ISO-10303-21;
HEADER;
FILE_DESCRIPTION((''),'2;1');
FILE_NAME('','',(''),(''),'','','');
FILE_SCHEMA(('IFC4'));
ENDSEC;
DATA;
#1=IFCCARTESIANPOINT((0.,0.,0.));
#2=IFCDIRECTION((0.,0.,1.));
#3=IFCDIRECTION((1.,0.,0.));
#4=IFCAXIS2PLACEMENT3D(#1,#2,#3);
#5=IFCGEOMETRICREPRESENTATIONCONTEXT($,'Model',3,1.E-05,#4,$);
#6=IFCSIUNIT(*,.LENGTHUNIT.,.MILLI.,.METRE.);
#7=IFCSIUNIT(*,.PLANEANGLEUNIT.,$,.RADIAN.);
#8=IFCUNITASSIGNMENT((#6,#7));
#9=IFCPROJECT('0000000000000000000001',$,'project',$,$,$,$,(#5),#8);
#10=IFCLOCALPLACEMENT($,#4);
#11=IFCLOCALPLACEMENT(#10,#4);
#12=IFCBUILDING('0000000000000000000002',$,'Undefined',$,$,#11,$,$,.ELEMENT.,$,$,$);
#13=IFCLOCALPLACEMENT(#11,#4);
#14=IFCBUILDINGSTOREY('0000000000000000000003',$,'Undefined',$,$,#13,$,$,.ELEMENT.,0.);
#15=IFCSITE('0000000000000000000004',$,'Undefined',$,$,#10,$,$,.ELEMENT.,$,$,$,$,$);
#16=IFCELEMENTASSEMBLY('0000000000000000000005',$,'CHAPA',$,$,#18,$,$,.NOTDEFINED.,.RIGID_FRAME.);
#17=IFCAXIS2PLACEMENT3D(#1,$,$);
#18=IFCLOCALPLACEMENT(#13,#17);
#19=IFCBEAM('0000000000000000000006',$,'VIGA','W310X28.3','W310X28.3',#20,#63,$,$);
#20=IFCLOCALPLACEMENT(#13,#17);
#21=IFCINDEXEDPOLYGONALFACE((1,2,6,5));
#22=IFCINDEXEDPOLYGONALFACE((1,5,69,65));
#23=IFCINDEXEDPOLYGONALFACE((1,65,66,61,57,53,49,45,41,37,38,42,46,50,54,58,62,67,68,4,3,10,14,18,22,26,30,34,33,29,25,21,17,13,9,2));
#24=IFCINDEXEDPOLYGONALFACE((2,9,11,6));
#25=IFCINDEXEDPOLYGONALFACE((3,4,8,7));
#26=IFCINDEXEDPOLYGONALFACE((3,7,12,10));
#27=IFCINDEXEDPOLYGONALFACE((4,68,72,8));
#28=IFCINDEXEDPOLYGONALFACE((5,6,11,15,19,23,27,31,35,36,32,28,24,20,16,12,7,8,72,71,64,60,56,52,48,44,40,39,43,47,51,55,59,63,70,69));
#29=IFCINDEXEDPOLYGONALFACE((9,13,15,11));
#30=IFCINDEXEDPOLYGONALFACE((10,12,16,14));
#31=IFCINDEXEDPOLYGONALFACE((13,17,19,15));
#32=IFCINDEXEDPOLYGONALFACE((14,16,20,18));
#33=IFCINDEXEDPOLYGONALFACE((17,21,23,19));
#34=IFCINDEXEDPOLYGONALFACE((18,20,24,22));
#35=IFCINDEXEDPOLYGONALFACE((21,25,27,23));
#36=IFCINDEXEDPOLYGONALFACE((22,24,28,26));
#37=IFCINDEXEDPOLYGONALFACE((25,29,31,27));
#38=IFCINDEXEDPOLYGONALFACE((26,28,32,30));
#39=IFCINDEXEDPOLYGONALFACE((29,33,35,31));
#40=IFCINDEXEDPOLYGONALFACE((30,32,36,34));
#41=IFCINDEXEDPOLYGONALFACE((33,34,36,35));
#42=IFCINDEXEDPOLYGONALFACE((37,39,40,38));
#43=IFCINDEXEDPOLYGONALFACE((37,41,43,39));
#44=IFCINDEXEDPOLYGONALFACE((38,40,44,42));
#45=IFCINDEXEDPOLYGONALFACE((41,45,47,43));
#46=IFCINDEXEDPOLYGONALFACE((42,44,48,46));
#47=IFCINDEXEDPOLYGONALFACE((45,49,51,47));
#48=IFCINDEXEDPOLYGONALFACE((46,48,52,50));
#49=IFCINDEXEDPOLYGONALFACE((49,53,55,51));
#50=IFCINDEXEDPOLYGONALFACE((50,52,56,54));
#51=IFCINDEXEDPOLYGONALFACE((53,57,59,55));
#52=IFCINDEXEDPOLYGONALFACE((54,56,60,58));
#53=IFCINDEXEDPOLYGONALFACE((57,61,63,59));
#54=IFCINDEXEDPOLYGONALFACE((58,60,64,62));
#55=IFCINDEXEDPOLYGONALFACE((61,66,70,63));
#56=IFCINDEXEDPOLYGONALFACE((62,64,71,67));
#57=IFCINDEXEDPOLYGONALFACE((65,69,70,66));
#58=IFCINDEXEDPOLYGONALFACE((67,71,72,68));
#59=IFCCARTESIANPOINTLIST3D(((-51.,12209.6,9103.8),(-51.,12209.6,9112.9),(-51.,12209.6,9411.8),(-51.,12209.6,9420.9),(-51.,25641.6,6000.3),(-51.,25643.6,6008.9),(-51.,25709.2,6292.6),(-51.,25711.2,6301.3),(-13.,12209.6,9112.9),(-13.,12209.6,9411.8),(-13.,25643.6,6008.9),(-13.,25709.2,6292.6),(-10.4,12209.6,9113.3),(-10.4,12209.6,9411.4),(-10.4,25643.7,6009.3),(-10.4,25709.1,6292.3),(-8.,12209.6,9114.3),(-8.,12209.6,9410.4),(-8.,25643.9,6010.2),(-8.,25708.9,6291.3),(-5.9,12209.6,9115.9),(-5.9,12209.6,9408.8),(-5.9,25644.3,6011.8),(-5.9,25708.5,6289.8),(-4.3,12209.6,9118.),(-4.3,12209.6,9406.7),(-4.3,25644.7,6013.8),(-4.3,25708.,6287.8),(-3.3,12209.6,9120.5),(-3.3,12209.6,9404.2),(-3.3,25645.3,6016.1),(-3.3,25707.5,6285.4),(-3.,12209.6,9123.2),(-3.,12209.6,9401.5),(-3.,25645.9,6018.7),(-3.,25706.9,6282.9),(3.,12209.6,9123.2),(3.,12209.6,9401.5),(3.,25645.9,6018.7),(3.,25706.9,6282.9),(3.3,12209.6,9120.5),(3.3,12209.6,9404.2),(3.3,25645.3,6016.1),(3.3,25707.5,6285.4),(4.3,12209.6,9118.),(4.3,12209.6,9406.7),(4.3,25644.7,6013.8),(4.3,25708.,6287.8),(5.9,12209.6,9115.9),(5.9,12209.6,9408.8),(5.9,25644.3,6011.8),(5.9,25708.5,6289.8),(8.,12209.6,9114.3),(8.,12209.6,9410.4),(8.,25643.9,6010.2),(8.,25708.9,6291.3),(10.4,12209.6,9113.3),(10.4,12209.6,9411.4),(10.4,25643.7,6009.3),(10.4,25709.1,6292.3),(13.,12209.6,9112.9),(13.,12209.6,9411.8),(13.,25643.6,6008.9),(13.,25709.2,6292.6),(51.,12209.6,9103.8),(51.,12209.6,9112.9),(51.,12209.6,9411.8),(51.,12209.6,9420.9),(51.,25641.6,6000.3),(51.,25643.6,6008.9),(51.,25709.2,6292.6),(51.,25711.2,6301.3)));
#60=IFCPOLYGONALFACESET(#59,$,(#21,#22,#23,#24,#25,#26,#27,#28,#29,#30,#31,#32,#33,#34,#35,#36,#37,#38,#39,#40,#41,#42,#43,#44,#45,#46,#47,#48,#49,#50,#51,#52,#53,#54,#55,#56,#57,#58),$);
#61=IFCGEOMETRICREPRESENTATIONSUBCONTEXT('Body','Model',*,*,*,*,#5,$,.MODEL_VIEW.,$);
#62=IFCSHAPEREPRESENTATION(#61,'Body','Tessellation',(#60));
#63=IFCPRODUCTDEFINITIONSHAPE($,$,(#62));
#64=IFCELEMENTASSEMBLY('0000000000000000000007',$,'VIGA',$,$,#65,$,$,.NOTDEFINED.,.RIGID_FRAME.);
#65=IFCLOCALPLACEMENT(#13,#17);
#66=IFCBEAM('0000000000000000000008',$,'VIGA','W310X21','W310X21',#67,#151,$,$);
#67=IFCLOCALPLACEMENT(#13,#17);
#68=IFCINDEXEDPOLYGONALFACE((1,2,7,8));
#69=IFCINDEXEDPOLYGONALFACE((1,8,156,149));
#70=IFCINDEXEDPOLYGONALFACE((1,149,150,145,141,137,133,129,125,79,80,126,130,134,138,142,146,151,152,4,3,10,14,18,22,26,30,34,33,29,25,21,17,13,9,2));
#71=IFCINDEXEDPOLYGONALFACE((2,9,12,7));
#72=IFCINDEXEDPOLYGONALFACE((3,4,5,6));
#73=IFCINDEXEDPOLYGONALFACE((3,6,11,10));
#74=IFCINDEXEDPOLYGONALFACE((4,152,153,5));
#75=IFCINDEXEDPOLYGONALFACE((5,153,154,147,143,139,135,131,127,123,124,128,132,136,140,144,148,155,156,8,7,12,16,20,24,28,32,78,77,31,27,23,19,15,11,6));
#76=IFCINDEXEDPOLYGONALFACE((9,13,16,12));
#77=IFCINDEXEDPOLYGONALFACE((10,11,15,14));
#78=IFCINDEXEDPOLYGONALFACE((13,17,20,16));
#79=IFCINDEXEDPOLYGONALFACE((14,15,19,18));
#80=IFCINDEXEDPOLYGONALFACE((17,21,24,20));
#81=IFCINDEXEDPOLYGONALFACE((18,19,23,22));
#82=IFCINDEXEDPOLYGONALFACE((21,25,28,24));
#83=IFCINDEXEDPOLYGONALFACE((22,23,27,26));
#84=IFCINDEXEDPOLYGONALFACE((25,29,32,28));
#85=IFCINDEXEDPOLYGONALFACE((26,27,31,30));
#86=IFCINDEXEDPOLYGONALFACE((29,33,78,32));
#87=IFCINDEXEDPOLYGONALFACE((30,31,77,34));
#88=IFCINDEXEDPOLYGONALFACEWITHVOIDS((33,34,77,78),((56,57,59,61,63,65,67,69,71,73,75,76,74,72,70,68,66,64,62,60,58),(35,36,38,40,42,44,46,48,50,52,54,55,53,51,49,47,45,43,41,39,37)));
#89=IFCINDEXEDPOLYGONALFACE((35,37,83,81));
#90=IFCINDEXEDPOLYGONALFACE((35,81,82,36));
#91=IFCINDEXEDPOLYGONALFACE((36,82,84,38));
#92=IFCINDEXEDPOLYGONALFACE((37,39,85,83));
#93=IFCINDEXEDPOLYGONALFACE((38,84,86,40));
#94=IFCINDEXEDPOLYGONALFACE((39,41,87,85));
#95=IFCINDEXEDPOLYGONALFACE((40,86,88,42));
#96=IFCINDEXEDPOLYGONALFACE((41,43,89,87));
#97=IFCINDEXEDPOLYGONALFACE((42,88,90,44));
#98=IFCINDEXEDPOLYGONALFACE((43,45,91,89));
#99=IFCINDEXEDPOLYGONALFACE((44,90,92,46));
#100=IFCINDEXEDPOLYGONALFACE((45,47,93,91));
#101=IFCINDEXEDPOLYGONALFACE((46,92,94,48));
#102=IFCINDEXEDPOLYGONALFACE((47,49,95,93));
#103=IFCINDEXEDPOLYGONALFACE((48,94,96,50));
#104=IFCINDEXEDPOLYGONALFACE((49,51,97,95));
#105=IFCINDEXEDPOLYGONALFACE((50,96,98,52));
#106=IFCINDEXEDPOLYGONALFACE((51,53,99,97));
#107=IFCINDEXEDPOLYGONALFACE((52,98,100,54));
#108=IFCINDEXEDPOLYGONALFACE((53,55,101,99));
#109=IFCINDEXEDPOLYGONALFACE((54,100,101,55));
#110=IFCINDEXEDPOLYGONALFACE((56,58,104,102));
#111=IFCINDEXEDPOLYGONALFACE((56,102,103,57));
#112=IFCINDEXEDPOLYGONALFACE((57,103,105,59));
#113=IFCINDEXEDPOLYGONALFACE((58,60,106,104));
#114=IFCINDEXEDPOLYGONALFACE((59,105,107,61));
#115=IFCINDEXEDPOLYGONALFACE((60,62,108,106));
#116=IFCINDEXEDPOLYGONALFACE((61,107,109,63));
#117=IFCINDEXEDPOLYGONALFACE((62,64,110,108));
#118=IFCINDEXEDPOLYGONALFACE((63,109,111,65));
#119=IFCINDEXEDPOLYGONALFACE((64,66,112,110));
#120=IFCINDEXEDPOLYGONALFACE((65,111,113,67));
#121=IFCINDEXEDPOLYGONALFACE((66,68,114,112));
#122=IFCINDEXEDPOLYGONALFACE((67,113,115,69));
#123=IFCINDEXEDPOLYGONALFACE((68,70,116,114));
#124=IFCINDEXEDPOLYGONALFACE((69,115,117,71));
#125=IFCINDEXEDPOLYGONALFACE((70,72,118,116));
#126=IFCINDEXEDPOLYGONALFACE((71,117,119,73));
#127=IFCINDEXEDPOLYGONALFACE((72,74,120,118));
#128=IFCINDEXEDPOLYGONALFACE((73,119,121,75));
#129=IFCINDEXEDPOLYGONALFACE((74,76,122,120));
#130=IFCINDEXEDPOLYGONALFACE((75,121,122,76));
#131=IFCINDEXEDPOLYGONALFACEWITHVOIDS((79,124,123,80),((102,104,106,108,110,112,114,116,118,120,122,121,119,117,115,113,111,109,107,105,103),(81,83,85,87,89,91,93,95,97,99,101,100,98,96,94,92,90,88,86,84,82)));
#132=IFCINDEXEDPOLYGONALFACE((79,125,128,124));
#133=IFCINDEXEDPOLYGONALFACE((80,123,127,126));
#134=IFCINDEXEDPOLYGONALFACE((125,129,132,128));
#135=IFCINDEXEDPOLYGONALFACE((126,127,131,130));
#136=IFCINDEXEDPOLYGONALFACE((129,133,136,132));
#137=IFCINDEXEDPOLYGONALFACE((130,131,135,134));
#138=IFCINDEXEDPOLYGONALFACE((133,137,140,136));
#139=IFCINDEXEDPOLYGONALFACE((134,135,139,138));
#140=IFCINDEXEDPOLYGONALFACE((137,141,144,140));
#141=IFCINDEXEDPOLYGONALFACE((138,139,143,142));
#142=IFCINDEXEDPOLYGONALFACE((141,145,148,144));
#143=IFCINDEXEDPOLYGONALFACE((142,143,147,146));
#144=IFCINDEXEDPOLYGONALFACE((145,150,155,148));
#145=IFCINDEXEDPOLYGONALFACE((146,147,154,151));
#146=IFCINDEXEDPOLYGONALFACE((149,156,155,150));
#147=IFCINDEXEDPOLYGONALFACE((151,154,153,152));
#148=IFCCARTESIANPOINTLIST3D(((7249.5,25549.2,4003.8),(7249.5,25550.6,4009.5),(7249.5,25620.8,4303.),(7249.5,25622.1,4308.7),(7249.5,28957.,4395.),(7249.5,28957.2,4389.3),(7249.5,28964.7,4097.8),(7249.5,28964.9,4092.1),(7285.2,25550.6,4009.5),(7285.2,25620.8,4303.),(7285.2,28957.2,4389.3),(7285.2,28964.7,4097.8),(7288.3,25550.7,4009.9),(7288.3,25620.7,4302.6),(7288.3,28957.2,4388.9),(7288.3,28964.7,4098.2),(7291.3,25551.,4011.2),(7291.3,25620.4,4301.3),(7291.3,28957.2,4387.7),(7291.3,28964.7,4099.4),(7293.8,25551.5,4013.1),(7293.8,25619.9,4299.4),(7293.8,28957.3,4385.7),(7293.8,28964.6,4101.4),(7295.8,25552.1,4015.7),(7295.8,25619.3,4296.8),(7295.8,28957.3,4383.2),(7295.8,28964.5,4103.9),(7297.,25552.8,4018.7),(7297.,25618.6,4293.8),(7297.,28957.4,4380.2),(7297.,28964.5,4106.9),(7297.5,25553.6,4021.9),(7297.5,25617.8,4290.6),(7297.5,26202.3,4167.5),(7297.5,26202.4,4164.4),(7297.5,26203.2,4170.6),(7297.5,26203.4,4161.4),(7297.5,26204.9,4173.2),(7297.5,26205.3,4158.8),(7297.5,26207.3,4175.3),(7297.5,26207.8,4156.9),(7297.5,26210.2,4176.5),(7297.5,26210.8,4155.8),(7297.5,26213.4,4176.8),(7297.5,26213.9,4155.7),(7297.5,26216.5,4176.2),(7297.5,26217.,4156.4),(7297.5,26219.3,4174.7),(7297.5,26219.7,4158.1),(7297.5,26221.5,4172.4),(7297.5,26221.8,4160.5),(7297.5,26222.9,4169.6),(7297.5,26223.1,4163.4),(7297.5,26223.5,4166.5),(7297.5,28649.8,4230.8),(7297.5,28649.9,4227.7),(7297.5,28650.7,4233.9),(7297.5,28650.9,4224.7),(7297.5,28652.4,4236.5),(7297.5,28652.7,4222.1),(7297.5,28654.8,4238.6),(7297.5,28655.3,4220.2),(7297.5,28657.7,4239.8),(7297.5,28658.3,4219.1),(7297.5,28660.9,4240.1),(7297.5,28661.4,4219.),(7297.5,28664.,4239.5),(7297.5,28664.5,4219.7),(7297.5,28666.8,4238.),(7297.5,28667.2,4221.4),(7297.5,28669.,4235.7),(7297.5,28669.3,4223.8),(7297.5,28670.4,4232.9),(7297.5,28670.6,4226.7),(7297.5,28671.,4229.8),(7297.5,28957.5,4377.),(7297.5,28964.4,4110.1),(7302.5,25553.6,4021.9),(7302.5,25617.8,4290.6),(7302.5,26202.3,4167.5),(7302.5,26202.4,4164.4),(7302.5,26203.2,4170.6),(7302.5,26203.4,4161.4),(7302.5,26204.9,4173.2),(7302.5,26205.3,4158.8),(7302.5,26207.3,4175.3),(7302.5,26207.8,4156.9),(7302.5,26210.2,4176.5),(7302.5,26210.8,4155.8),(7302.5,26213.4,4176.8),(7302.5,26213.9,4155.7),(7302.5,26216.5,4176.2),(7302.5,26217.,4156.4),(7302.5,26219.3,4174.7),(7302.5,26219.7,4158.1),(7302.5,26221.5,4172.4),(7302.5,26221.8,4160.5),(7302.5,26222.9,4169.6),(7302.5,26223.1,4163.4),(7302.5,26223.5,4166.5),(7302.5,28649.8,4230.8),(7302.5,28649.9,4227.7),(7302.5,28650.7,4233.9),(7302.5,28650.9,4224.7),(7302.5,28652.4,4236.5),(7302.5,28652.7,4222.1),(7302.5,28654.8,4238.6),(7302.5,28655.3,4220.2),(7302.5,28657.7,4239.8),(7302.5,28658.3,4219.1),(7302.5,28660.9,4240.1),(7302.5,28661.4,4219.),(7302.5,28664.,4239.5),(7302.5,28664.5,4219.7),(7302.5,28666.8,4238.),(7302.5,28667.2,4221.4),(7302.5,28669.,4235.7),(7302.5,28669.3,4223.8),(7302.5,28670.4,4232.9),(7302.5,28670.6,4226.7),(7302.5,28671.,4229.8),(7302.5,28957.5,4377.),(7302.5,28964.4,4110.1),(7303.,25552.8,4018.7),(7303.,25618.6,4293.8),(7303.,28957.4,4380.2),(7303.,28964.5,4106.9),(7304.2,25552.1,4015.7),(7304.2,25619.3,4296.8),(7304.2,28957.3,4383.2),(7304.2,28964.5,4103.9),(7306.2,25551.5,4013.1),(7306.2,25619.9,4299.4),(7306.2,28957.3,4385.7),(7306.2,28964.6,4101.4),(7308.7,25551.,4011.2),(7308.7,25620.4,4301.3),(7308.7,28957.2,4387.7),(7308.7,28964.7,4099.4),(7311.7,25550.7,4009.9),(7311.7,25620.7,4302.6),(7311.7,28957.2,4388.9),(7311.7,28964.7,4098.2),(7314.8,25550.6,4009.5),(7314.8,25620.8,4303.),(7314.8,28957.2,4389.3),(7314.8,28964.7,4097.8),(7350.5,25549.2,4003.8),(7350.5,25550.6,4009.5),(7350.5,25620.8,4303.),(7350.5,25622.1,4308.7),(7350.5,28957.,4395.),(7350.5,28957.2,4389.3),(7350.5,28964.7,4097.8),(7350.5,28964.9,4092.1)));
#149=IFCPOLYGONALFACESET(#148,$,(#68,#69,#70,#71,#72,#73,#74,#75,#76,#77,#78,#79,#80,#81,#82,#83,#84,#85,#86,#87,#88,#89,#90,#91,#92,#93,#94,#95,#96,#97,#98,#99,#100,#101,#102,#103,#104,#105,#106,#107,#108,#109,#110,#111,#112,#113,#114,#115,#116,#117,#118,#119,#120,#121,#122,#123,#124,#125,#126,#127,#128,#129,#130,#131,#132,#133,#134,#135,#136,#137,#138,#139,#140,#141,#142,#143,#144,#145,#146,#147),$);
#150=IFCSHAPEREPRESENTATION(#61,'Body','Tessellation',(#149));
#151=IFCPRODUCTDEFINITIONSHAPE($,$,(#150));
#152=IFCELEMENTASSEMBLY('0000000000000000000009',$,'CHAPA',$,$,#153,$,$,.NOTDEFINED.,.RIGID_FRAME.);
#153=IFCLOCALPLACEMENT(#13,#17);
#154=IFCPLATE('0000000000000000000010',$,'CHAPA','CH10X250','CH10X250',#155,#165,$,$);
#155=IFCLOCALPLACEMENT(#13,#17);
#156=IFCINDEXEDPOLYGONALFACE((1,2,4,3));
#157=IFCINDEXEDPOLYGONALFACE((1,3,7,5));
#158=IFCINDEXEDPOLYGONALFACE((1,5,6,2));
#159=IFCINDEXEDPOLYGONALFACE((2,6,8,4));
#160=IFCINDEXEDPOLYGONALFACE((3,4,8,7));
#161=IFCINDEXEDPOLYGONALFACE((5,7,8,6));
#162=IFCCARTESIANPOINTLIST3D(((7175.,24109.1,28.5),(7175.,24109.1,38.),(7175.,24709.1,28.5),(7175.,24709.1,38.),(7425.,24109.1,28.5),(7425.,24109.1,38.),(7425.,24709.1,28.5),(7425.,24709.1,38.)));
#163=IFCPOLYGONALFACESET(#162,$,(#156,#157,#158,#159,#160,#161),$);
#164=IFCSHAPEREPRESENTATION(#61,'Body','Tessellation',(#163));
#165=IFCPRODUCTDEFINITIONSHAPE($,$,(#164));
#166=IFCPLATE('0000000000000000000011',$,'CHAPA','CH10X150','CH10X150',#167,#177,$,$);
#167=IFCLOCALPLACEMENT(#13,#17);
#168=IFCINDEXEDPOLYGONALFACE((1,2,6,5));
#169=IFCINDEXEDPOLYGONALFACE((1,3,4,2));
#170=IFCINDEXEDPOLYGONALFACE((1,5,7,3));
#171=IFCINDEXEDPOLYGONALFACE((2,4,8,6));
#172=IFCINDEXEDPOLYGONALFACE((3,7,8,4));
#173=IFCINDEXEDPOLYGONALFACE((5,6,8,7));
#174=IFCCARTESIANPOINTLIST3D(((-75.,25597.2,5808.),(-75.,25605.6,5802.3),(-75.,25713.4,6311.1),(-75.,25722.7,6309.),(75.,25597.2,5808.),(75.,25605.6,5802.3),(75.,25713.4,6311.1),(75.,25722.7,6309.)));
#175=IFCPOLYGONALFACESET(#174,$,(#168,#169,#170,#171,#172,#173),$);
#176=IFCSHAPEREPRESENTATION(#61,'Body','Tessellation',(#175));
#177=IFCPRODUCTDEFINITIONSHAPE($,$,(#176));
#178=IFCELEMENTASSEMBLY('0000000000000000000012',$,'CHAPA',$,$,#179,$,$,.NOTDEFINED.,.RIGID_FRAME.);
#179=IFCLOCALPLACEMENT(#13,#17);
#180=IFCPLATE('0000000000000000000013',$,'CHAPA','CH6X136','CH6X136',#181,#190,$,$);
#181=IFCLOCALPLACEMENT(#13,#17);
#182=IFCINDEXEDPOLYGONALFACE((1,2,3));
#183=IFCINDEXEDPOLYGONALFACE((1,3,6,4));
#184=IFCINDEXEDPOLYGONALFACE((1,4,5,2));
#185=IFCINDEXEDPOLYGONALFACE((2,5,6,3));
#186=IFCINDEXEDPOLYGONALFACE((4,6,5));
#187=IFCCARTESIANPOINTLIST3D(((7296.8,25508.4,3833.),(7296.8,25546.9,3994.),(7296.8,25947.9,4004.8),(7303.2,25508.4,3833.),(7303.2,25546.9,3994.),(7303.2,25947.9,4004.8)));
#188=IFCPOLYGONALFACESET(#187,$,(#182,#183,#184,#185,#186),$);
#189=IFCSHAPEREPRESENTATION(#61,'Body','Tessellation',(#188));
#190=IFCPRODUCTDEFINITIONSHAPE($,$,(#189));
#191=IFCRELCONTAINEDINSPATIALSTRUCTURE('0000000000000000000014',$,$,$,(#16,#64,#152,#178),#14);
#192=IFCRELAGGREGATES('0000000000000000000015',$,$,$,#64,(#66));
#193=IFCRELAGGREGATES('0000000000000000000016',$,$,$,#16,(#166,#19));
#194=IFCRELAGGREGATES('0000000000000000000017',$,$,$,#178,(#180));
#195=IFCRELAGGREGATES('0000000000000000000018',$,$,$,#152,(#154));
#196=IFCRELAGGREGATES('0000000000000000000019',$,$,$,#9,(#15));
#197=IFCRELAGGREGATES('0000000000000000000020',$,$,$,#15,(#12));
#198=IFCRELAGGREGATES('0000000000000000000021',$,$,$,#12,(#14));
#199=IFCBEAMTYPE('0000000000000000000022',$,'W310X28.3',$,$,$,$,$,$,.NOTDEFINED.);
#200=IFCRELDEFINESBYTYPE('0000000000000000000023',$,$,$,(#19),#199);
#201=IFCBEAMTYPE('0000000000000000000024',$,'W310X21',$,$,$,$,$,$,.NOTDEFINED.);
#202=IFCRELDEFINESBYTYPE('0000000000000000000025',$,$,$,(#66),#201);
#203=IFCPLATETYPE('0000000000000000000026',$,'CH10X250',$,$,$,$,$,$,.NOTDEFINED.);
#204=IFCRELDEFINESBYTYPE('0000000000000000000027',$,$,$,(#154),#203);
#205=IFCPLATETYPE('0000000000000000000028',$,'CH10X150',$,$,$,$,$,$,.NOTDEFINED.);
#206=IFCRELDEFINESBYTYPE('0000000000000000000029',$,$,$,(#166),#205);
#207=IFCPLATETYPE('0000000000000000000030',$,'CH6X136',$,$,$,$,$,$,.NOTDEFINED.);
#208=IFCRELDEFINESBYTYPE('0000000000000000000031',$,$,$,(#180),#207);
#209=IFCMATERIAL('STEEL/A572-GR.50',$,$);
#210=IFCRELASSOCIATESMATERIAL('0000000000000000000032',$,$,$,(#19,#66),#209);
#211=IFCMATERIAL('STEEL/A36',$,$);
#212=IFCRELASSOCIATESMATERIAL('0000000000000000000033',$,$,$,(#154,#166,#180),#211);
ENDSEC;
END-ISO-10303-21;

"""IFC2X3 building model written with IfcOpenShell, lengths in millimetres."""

from ifc_helpers import new_model, si_unit, frame, origin_with_axes, origin_2d_with_axis, place, context, subcontext, project, spatial, polyline, circle, i_section, outline, extrude, boolean, clip, halfspace, material, type_object, element, aggregate, save


model = new_model("IFC2X3")

# Units and contexts
model_context = context("Model", 3, precision=1e-05, world=origin_with_axes())
body_context = subcontext(model_context, "Body", "Model", "MODEL_VIEW")
ifc_project = project(units=[si_unit("LENGTHUNIT", "METRE", prefix="MILLI"), si_unit("PLANEANGLEUNIT", "RADIAN")], contexts=[model_context])

# Site, building, storey
site_placement = place(None, origin_with_axes())
site = spatial("IfcSite", under=ifc_project, at=site_placement, Name="Undefined", CompositionType="ELEMENT")
building_placement = place(site_placement, origin_with_axes())
building = spatial("IfcBuilding", under=site, at=building_placement, Name="Undefined", CompositionType="ELEMENT")
storey_placement = place(building_placement, origin_with_axes())
storey = spatial("IfcBuildingStorey", under=building, at=storey_placement, Name="Undefined", CompositionType="ELEMENT", Elevation=0.0)

# Element assemblies, beams
ifc_material_1 = material(Name="STEEL/A572-GR.50")
beam_type_1 = type_object("IfcBeamType", Name="W310X28.3", PredefinedType="NOTDEFINED")
assembly_1_placement = place(storey_placement, origin_with_axes())
assembly_1 = element("IfcElementAssembly", 1, at=assembly_1_placement, inside=storey, Name="CHAPA", AssemblyPlace="NOTDEFINED", PredefinedType="RIGID_FRAME")
beam_1_placement = place(assembly_1_placement, frame((0.0, 25676.4, 6150.8), z_axis=(0.0, -0.225124, -0.97433), x_axis=(0.0, -0.97433, 0.225124)))
beam_1 = element("IfcBeam", 2, at=beam_1_placement, type_object=beam_type_1, material=ifc_material_1, Name="VIGA", Description="W310X28.3", ObjectType="W310X28.3", context=body_context, shape_type="Clipping", body=[
    clip(extrude(i_section(OverallWidth=102.0, OverallDepth=309.0, WebThickness=6.0, FlangeThickness=8.9, FilletRadius=10.0, at=origin_2d_with_axis()), frame((13995.7, 0.0, 0.0), z_axis=(-1.0, 0.0, 0.0), x_axis=(0.0, -1.0, 0.0)), (0.0, 0.0, 1.0), 13995.7), halfspace(frame((13786.4, 0.0, 152.3), z_axis=(0.97433, 0.0, 0.225124), x_axis=(0.225124, 0.0, -0.97433)), False)),
])
assembly_2_placement = place(storey_placement, origin_with_axes())
assembly_2 = element("IfcElementAssembly", 3, at=assembly_2_placement, inside=storey, Name="VIGA", AssemblyPlace="NOTDEFINED", PredefinedType="RIGID_FRAME")
beam_type_2 = type_object("IfcBeamType", Name="W310X21", PredefinedType="NOTDEFINED")
beam_2_placement = place(assembly_2_placement, frame((7300.0, 25403.9, 4151.6), z_axis=(0.0, -0.025855, 0.999666), x_axis=(0.0, 0.999666, 0.025855)))
beam_2 = element("IfcBeam", 4, at=beam_2_placement, type_object=beam_type_2, material=ifc_material_1, Name="VIGA", Description="W310X21", ObjectType="W310X21", context=body_context, shape_type="CSG", body=[
    boolean("DIFFERENCE", boolean("DIFFERENCE", boolean("DIFFERENCE", extrude(i_section(OverallWidth=101.0, OverallDepth=303.0, WebThickness=5.1, FlangeThickness=5.7, FilletRadius=12.3, at=origin_2d_with_axis()), frame((3558.2, 0.0, 0.0), z_axis=(-1.0, 0.0, 0.0), x_axis=(0.0, -1.0, 0.0)), (0.0, 0.0, 1.0), 3558.2), extrude(circle(Radius=10.6, at=origin_2d_with_axis()), frame((809.1, 100.0, -6.3), z_axis=(0.0, -1.0, 0.0), x_axis=(1.0, 0.0, 0.0)), (0.0, 0.0, 1.0), 200.0)), extrude(circle(Radius=10.6, at=origin_2d_with_axis()), frame((3257.4, 100.0, -6.3), z_axis=(0.0, -1.0, 0.0), x_axis=(1.0, 0.0, 0.0)), (0.0, 0.0, 1.0), 200.0)), halfspace(frame((141.4, -50.5, -151.7), z_axis=(-0.966259, 0.0, 0.257573), x_axis=(0.0, 1.0, 0.0)), False)),
])
aggregate(assembly_2, [beam_2])

# Element assembly, plate
assembly_3_placement = place(storey_placement, origin_with_axes())
assembly_3 = element("IfcElementAssembly", 5, at=assembly_3_placement, inside=storey, Name="CHAPA", AssemblyPlace="NOTDEFINED", PredefinedType="RIGID_FRAME")
ifc_material_2 = material(Name="STEEL/A36")
plate_type_1 = type_object("IfcPlateType", Name="CH10X250", PredefinedType="NOTDEFINED")
plate_1_placement = place(assembly_3_placement, frame((7175.0, 24709.1, 33.2), z_axis=(0.0, 0.0, -1.0), x_axis=(1.0, 0.0, 0.0)))
plate_1 = element("IfcPlate", 6, at=plate_1_placement, type_object=plate_type_1, material=ifc_material_2, Name="CHAPA", Description="CH10X250", ObjectType="CH10X250", context=body_context, shape_type="SweptSolid", body=[
    extrude(outline(polyline([(0.0, 0.0), (250.0, 0.0), (250.0, 600.0), (0.0, 600.0), (0.0, 0.0)])), frame((0.0, 0.0, -4.8), z_axis=(0.0, 0.0, 1.0), x_axis=(1.0, 0.0, 0.0)), (0.0, 0.0, 1.0), 9.5),
])

# Plate
plate_type_2 = type_object("IfcPlateType", Name="CH10X150", PredefinedType="NOTDEFINED")
plate_2_placement = place(assembly_1_placement, frame((75.0, 25718.1, 6310.1), z_axis=(0.0, 0.97433, -0.225124), x_axis=(0.0, -0.225124, -0.97433)))
plate_2 = element("IfcPlate", 7, at=plate_2_placement, type_object=plate_type_2, material=ifc_material_2, Name="CHAPA", Description="CH10X150", ObjectType="CH10X150", context=body_context, shape_type="Clipping", body=[
    clip(extrude(outline(polyline([(0.0, 0.0), (520.0, 0.0), (520.0, 150.0), (0.0, 150.0), (0.0, 0.0)])), frame((0.0, 0.0, -4.8), z_axis=(0.0, 0.0, 1.0), x_axis=(1.0, 0.0, 0.0)), (0.0, 0.0, 1.0), 9.5), halfspace(frame((516.4, -500.0, -4.7), z_axis=(0.934951, 0.0, -0.354778), x_axis=(0.354778, 0.0, 0.934951)), False)),
])
aggregate(assembly_1, [plate_2, beam_1])

# Element assembly, plate
assembly_4_placement = place(storey_placement, origin_with_axes())
assembly_4 = element("IfcElementAssembly", 8, at=assembly_4_placement, inside=storey, Name="CHAPA", AssemblyPlace="NOTDEFINED", PredefinedType="RIGID_FRAME")
plate_type_3 = type_object("IfcPlateType", Name="CH6X136", PredefinedType="NOTDEFINED")
plate_3_placement = place(assembly_4_placement, frame((7300.0, 25546.9, 3994.0), z_axis=(-1.0, 0.0, 0.0), x_axis=(0.0, 0.999636, 0.026972)))
plate_3 = element("IfcPlate", 9, at=plate_3_placement, type_object=plate_type_3, material=ifc_material_2, Name="CHAPA", Description="CH6X136", ObjectType="CH6X136", context=body_context, shape_type="SweptSolid", body=[
    extrude(outline(polyline([(0.0, 0.0), (401.1, 0.0), (-42.8, 159.9), (0.0, 0.0)])), frame((0.0, 0.0, -3.1), z_axis=(0.0, 0.0, 1.0), x_axis=(1.0, 0.0, 0.0)), (0.0, 0.0, 1.0), 6.3),
])
aggregate(assembly_4, [plate_3])

aggregate(assembly_3, [plate_1])

save(model, "model.ifc")
